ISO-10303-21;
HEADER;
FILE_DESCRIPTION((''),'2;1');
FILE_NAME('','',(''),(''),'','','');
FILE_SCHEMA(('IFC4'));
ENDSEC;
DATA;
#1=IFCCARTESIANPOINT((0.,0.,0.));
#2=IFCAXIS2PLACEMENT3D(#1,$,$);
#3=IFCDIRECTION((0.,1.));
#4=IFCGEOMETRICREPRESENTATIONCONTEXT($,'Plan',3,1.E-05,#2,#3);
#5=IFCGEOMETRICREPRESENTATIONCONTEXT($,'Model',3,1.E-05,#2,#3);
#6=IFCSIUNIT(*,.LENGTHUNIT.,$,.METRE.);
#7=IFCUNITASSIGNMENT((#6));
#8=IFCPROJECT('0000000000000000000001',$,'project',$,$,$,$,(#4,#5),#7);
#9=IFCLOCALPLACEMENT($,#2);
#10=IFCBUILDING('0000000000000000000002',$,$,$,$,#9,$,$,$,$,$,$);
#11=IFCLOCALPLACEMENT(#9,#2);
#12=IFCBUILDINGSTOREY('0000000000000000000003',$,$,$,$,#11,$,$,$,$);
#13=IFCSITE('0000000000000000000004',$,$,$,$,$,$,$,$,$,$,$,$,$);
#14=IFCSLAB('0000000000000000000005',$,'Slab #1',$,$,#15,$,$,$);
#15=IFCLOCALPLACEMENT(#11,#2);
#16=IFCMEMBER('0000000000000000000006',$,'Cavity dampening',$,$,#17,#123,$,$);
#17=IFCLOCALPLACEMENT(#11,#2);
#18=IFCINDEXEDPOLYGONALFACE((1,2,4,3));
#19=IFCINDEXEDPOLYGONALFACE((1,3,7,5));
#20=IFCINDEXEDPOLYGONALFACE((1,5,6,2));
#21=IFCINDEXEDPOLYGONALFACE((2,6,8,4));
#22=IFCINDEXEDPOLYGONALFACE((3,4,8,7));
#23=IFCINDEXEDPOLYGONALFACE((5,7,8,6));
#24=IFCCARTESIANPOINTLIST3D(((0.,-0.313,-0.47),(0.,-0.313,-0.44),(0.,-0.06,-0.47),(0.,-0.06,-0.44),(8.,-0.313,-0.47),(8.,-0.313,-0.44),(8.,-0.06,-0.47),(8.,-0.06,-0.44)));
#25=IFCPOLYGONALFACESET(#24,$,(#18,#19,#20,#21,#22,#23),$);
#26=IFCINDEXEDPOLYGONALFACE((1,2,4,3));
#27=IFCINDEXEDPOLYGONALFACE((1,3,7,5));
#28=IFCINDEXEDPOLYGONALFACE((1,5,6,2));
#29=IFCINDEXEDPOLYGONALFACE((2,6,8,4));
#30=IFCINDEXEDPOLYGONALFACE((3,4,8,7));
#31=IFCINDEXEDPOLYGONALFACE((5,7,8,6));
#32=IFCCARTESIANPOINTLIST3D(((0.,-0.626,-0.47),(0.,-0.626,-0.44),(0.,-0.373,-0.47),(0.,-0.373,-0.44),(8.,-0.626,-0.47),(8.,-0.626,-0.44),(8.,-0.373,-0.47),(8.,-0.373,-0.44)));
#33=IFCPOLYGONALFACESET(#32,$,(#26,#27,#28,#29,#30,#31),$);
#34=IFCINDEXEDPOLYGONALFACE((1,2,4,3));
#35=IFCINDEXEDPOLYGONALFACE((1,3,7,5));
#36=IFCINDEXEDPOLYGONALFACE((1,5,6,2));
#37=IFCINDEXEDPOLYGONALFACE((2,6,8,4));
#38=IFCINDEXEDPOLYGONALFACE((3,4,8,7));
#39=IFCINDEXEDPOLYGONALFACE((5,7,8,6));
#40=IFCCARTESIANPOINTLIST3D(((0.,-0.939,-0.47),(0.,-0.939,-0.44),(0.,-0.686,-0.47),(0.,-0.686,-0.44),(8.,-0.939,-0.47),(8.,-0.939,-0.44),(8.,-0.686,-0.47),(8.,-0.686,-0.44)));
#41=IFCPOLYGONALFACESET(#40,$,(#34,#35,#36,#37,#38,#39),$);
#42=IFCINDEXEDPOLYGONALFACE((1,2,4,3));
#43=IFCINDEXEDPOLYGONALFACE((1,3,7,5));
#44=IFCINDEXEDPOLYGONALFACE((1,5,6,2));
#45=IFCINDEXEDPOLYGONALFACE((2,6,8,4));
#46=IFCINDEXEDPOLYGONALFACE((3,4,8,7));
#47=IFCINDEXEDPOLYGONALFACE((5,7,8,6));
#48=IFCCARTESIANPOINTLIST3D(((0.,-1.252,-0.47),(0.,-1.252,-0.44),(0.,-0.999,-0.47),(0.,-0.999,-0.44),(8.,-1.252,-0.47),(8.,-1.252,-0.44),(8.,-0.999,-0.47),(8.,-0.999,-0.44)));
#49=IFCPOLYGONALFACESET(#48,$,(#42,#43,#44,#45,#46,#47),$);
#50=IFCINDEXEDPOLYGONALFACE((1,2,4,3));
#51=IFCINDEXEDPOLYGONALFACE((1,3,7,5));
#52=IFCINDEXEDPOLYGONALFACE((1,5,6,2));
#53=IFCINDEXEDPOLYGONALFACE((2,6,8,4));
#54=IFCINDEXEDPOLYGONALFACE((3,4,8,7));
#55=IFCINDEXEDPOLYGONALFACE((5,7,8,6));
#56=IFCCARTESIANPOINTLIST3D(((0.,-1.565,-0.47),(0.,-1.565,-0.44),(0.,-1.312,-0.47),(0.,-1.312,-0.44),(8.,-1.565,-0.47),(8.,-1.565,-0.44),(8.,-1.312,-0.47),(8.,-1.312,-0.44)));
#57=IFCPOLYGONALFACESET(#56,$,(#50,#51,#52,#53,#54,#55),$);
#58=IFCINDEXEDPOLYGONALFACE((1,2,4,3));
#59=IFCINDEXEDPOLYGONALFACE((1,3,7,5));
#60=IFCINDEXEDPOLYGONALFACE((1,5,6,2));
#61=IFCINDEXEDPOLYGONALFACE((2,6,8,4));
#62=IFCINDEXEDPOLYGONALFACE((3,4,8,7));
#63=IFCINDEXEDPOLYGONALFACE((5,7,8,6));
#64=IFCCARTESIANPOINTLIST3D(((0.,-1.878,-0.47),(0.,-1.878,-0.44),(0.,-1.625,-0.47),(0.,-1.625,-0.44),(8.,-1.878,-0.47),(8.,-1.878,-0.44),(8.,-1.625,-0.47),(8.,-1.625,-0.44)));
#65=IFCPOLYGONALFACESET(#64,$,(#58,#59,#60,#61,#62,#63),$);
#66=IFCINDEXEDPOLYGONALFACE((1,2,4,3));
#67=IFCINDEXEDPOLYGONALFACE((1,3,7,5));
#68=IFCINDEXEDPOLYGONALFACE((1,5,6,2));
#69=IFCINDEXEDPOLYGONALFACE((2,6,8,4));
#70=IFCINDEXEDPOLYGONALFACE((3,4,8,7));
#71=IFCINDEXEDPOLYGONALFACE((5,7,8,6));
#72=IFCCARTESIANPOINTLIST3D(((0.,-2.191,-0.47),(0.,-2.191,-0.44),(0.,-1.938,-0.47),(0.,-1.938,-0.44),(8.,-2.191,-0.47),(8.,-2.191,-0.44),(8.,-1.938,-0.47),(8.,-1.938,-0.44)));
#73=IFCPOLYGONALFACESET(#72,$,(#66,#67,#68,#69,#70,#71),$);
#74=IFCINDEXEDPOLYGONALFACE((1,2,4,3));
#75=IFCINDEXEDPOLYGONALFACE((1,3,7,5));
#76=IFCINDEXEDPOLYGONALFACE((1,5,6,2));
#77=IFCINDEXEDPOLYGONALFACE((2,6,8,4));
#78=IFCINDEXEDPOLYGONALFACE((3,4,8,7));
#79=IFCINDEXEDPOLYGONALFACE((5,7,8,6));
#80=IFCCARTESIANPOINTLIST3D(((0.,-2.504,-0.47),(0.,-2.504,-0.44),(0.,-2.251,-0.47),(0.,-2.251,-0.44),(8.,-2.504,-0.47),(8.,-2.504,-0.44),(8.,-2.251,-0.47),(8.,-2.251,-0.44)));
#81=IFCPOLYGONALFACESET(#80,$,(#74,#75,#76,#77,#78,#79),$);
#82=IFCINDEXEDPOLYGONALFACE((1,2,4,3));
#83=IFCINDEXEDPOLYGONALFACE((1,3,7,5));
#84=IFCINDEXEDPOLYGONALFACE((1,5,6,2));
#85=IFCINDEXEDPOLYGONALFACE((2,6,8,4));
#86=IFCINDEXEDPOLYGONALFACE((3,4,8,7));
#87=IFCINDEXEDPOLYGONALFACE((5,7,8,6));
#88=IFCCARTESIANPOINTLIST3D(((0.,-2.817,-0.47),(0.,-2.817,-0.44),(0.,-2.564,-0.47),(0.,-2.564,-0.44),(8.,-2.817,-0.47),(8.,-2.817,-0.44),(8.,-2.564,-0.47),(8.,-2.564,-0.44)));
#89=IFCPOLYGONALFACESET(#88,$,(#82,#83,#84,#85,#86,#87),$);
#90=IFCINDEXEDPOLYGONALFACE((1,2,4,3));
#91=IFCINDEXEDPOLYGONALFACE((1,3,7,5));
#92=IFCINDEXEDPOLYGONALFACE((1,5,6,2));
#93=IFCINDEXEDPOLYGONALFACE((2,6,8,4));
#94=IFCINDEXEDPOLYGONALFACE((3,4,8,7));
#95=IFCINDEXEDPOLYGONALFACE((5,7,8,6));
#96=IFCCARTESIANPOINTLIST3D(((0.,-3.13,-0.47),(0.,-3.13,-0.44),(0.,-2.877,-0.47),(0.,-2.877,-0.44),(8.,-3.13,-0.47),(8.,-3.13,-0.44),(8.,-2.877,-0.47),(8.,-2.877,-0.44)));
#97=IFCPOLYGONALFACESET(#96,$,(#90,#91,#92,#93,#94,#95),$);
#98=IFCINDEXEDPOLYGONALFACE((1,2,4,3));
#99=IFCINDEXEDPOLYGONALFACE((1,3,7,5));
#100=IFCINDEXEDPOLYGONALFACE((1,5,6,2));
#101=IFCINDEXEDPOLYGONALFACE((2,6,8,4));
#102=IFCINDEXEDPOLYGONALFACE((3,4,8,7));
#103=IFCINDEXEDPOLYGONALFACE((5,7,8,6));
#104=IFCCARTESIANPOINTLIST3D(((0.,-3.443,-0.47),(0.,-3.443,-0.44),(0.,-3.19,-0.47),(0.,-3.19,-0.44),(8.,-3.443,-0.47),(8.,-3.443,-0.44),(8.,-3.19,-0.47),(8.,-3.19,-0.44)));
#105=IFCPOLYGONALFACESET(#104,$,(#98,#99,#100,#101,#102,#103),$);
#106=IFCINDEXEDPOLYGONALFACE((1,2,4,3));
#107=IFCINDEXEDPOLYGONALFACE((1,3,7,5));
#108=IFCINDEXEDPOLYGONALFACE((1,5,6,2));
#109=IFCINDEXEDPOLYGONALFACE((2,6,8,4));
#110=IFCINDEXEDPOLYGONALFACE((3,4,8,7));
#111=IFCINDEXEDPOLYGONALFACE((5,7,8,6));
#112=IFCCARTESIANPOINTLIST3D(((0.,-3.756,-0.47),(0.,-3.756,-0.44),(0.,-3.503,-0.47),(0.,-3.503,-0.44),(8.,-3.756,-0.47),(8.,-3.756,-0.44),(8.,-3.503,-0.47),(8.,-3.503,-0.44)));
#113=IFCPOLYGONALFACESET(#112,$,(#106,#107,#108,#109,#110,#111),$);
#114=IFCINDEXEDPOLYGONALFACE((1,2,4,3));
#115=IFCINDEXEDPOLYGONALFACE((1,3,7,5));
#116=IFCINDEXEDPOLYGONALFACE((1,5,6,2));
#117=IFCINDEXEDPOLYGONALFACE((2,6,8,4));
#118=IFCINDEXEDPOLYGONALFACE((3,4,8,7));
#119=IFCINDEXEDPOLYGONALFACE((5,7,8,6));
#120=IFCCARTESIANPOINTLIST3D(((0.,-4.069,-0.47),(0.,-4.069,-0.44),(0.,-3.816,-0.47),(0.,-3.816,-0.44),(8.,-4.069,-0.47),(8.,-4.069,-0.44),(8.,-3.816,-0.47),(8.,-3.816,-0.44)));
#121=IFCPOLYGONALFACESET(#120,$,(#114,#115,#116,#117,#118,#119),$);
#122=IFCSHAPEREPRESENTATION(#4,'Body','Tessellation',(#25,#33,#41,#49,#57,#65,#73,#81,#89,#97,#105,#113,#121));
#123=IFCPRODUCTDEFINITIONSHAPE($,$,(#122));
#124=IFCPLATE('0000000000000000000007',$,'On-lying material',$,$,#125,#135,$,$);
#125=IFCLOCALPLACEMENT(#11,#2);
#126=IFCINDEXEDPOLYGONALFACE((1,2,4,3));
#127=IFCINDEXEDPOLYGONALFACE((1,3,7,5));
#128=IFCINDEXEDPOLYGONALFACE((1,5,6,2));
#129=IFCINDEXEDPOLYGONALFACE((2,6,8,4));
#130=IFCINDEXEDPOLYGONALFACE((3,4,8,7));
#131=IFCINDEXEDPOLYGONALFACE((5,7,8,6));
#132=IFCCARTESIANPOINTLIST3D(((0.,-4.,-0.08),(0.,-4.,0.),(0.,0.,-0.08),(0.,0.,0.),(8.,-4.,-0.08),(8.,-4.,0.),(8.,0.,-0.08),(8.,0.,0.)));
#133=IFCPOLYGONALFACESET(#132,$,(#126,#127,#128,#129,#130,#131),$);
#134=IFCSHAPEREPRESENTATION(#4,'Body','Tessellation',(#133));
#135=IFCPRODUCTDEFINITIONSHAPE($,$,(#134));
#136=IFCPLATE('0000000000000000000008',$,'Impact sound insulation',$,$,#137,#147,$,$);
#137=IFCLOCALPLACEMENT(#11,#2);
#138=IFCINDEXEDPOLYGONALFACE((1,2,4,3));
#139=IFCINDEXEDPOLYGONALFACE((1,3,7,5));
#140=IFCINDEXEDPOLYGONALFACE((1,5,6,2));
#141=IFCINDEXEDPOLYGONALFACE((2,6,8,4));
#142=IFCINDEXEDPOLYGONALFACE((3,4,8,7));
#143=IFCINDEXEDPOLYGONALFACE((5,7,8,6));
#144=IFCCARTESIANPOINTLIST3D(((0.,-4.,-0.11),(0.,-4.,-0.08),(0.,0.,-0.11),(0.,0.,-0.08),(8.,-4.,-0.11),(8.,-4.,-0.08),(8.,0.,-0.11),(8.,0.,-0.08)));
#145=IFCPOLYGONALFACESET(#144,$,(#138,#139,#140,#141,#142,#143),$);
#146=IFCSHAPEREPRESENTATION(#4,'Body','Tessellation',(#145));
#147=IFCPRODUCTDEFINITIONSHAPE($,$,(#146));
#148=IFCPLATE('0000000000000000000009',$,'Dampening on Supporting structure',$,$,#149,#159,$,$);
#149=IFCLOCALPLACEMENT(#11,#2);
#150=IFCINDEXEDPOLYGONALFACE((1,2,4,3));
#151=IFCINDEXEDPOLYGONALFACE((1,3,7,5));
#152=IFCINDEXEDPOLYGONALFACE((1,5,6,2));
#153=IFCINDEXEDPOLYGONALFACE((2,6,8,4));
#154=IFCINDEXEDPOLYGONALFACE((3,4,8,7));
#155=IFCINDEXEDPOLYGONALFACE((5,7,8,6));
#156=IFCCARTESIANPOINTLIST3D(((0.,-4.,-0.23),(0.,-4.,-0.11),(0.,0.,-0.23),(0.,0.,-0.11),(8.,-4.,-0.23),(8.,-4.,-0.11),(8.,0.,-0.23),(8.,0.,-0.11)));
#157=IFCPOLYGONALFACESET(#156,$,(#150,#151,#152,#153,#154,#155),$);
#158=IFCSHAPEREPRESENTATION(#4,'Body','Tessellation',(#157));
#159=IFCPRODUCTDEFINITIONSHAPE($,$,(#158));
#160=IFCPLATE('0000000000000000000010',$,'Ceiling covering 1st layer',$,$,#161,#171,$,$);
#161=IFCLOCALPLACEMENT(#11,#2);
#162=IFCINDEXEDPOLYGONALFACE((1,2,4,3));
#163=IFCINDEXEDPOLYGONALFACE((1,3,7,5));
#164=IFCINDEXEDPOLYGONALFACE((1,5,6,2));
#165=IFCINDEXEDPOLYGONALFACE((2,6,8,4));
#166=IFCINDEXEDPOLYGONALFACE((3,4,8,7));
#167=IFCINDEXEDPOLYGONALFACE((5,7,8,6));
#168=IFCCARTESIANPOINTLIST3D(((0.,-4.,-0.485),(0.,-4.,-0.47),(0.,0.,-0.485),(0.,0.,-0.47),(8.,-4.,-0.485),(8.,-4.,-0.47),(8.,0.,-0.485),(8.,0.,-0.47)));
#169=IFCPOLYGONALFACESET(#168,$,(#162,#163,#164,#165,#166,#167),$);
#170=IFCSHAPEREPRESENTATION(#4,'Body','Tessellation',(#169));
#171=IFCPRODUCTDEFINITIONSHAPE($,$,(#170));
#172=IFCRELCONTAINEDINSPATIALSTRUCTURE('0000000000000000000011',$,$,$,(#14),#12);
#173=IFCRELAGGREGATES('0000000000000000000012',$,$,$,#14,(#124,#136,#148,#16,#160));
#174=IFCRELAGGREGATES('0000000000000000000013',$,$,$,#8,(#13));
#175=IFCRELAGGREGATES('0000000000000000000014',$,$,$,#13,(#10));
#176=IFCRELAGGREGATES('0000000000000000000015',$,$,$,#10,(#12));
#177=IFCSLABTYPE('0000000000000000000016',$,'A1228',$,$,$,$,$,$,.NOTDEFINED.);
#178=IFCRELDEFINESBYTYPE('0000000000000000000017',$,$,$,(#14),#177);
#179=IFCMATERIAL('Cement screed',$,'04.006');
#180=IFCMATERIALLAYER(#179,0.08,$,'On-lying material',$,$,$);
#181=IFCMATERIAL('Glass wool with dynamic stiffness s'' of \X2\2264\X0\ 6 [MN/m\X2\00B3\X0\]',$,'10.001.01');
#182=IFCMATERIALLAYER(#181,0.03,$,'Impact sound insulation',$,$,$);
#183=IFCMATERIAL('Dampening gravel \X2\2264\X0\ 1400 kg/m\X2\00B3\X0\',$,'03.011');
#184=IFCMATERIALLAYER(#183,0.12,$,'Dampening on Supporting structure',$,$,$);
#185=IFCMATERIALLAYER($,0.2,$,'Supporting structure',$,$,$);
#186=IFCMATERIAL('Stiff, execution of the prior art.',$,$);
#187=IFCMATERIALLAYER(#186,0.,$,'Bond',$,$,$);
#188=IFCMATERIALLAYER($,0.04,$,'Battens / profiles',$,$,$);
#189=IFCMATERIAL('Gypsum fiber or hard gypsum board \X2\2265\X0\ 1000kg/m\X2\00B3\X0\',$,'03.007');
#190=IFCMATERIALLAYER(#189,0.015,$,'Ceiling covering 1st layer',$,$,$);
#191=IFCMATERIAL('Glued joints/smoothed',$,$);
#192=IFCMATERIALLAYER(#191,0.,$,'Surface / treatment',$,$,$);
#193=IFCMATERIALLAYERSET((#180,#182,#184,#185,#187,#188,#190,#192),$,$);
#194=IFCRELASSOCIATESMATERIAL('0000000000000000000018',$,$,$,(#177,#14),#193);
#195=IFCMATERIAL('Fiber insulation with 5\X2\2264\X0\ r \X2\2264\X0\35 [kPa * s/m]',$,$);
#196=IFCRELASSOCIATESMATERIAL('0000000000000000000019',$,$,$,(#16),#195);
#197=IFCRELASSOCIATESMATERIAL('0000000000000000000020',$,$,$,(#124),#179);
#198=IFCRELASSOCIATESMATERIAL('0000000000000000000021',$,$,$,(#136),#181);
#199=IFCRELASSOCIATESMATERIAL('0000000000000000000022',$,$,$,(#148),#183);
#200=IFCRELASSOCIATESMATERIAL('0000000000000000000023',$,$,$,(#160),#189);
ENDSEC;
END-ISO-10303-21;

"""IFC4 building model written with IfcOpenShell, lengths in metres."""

from ifc_helpers import new_model, si_unit, direction, frame, frame_2d, origin, origin_with_axes, place, context, project, spatial, rectangle, extrude, material, layer, layer_set, type_object, element, aggregate, save


model = new_model("IFC4")

# Units and contexts
plan_context = context("Plan", 3, precision=1e-05, world=origin(), true_north=direction((0.0, 1.0)))
model_context = context("Model", 3, precision=1e-05, world=origin(), true_north=direction((0.0, 1.0)))
ifc_project = project(units=[si_unit("LENGTHUNIT", "METRE")], contexts=[plan_context, model_context])

# Site, building, storey
site = spatial("IfcSite", under=ifc_project)
building_placement = place(None, origin())
building = spatial("IfcBuilding", under=site, at=building_placement)
storey_placement = place(building_placement, origin())
storey = spatial("IfcBuildingStorey", under=building, at=storey_placement)

# Slab, member, plates
ifc_material_1 = material(Name="Cement screed", Category="04.006")
ifc_layer_1 = layer(ifc_material_1, 0.08, Name="On-lying material")
ifc_material_2 = material(Name="Glass wool with dynamic stiffness s' of ≤ 6 [MN/m³]", Category="10.001.01")
ifc_layer_2 = layer(ifc_material_2, 0.03, Name="Impact sound insulation")
ifc_material_3 = material(Name="Dampening gravel ≤ 1400 kg/m³", Category="03.011")
ifc_layer_3 = layer(ifc_material_3, 0.12, Name="Dampening on Supporting structure")
ifc_layer_4 = layer(None, 0.2, Name="Supporting structure")
ifc_material_4 = material(Name="Stiff, execution of the prior art.")
ifc_layer_5 = layer(ifc_material_4, 0.0, Name="Bond")
ifc_layer_6 = layer(None, 0.04, Name="Battens / profiles")
ifc_material_5 = material(Name="Gypsum fiber or hard gypsum board ≥ 1000kg/m³", Category="03.007")
ifc_layer_7 = layer(ifc_material_5, 0.015, Name="Ceiling covering 1st layer")
ifc_material_6 = material(Name="Glued joints/smoothed")
ifc_layer_8 = layer(ifc_material_6, 0.0, Name="Surface / treatment")
ifc_layer_set = layer_set([ifc_layer_1, ifc_layer_2, ifc_layer_3, ifc_layer_4, ifc_layer_5, ifc_layer_6, ifc_layer_7, ifc_layer_8])
slab_type = type_object("IfcSlabType", Name="A1228", PredefinedType="NOTDEFINED", material=ifc_layer_set)
slab_placement = place(None, frame((0.0, 0.0, 0.0), z_axis=(0.0, 0.0, -1.0), x_axis=(1.0, 0.0, 0.0)))
slab = element("IfcSlab", 1, at=slab_placement, inside=storey, type_object=slab_type, material=ifc_layer_set, Name="Slab #1")
ifc_material_7 = material(Name="Fiber insulation with 5≤ r ≤35 [kPa * s/m]")
member_1_placement = place(slab_placement, origin())
member_1 = element("IfcMember", 2, at=member_1_placement, material=ifc_material_7, Name="Cavity dampening", context=plan_context, shape_type="SweptSolid", body=[
    extrude(rectangle(XDim=0.253, YDim=0.03, at=frame_2d((0.1265, 0.015), x_axis=(1.0, 0.0))), frame((0.0, 0.06, 0.44), z_axis=(1.0, 0.0, 0.0), x_axis=(0.0, 1.0, 0.0)), (0.0, 0.0, 1.0), 8.0),
    extrude(rectangle(XDim=0.253, YDim=0.03, at=frame_2d((0.1265, 0.015), x_axis=(1.0, 0.0))), frame((0.0, 0.373, 0.44), z_axis=(1.0, 0.0, 0.0), x_axis=(0.0, 1.0, 0.0)), (0.0, 0.0, 1.0), 8.0),
    extrude(rectangle(XDim=0.253, YDim=0.03, at=frame_2d((0.1265, 0.015), x_axis=(1.0, 0.0))), frame((0.0, 0.686, 0.44), z_axis=(1.0, 0.0, 0.0), x_axis=(0.0, 1.0, 0.0)), (0.0, 0.0, 1.0), 8.0),
    extrude(rectangle(XDim=0.253, YDim=0.03, at=frame_2d((0.1265, 0.015), x_axis=(1.0, 0.0))), frame((0.0, 0.999, 0.44), z_axis=(1.0, 0.0, 0.0), x_axis=(0.0, 1.0, 0.0)), (0.0, 0.0, 1.0), 8.0),
    extrude(rectangle(XDim=0.253, YDim=0.03, at=frame_2d((0.1265, 0.015), x_axis=(1.0, 0.0))), frame((0.0, 1.312, 0.44), z_axis=(1.0, 0.0, 0.0), x_axis=(0.0, 1.0, 0.0)), (0.0, 0.0, 1.0), 8.0),
    extrude(rectangle(XDim=0.253, YDim=0.03, at=frame_2d((0.1265, 0.015), x_axis=(1.0, 0.0))), frame((0.0, 1.625, 0.44), z_axis=(1.0, 0.0, 0.0), x_axis=(0.0, 1.0, 0.0)), (0.0, 0.0, 1.0), 8.0),
    extrude(rectangle(XDim=0.253, YDim=0.03, at=frame_2d((0.1265, 0.015), x_axis=(1.0, 0.0))), frame((0.0, 1.938, 0.44), z_axis=(1.0, 0.0, 0.0), x_axis=(0.0, 1.0, 0.0)), (0.0, 0.0, 1.0), 8.0),
    extrude(rectangle(XDim=0.253, YDim=0.03, at=frame_2d((0.1265, 0.015), x_axis=(1.0, 0.0))), frame((0.0, 2.251, 0.44), z_axis=(1.0, 0.0, 0.0), x_axis=(0.0, 1.0, 0.0)), (0.0, 0.0, 1.0), 8.0),
    extrude(rectangle(XDim=0.253, YDim=0.03, at=frame_2d((0.1265, 0.015), x_axis=(1.0, 0.0))), frame((0.0, 2.564, 0.44), z_axis=(1.0, 0.0, 0.0), x_axis=(0.0, 1.0, 0.0)), (0.0, 0.0, 1.0), 8.0),
    extrude(rectangle(XDim=0.253, YDim=0.03, at=frame_2d((0.1265, 0.015), x_axis=(1.0, 0.0))), frame((0.0, 2.877, 0.44), z_axis=(1.0, 0.0, 0.0), x_axis=(0.0, 1.0, 0.0)), (0.0, 0.0, 1.0), 8.0),
    extrude(rectangle(XDim=0.253, YDim=0.03, at=frame_2d((0.1265, 0.015), x_axis=(1.0, 0.0))), frame((0.0, 3.19, 0.44), z_axis=(1.0, 0.0, 0.0), x_axis=(0.0, 1.0, 0.0)), (0.0, 0.0, 1.0), 8.0),
    extrude(rectangle(XDim=0.253, YDim=0.03, at=frame_2d((0.1265, 0.015), x_axis=(1.0, 0.0))), frame((0.0, 3.503, 0.44), z_axis=(1.0, 0.0, 0.0), x_axis=(0.0, 1.0, 0.0)), (0.0, 0.0, 1.0), 8.0),
    extrude(rectangle(XDim=0.253, YDim=0.03, at=frame_2d((0.1265, 0.015), x_axis=(1.0, 0.0))), frame((0.0, 3.816, 0.44), z_axis=(1.0, 0.0, 0.0), x_axis=(0.0, 1.0, 0.0)), (0.0, 0.0, 1.0), 8.0),
])
plate_1_placement = place(slab_placement, origin())
plate_1 = element("IfcPlate", 3, at=plate_1_placement, material=ifc_material_1, Name="On-lying material", context=plan_context, shape_type="SweptSolid", body=[
    extrude(rectangle(XDim=8.0, YDim=4.0, at=frame_2d((4.0, 2.0), x_axis=(1.0, 0.0))), origin_with_axes(), (0.0, 0.0, 1.0), 0.08),
])
plate_2_placement = place(slab_placement, origin())
plate_2 = element("IfcPlate", 4, at=plate_2_placement, material=ifc_material_2, Name="Impact sound insulation", context=plan_context, shape_type="SweptSolid", body=[
    extrude(rectangle(XDim=8.0, YDim=4.0, at=frame_2d((4.0, 2.0), x_axis=(1.0, 0.0))), frame((0.0, 0.0, 0.08), z_axis=(0.0, 0.0, 1.0), x_axis=(1.0, 0.0, 0.0)), (0.0, 0.0, 1.0), 0.03),
])
plate_3_placement = place(slab_placement, origin())
plate_3 = element("IfcPlate", 5, at=plate_3_placement, material=ifc_material_3, Name="Dampening on Supporting structure", context=plan_context, shape_type="SweptSolid", body=[
    extrude(rectangle(XDim=8.0, YDim=4.0, at=frame_2d((4.0, 2.0), x_axis=(1.0, 0.0))), frame((0.0, 0.0, 0.11), z_axis=(0.0, 0.0, 1.0), x_axis=(1.0, 0.0, 0.0)), (0.0, 0.0, 1.0), 0.12),
])
plate_4_placement = place(slab_placement, origin())
plate_4 = element("IfcPlate", 6, at=plate_4_placement, material=ifc_material_5, Name="Ceiling covering 1st layer", context=plan_context, shape_type="SweptSolid", body=[
    extrude(rectangle(XDim=8.0, YDim=4.0, at=frame_2d((4.0, 2.0), x_axis=(1.0, 0.0))), frame((0.0, 0.0, 0.47), z_axis=(0.0, 0.0, 1.0), x_axis=(1.0, 0.0, 0.0)), (0.0, 0.0, 1.0), 0.015),
])
aggregate(slab, [plate_1, plate_2, plate_3, member_1, plate_4])

save(model, "model.ifc")
